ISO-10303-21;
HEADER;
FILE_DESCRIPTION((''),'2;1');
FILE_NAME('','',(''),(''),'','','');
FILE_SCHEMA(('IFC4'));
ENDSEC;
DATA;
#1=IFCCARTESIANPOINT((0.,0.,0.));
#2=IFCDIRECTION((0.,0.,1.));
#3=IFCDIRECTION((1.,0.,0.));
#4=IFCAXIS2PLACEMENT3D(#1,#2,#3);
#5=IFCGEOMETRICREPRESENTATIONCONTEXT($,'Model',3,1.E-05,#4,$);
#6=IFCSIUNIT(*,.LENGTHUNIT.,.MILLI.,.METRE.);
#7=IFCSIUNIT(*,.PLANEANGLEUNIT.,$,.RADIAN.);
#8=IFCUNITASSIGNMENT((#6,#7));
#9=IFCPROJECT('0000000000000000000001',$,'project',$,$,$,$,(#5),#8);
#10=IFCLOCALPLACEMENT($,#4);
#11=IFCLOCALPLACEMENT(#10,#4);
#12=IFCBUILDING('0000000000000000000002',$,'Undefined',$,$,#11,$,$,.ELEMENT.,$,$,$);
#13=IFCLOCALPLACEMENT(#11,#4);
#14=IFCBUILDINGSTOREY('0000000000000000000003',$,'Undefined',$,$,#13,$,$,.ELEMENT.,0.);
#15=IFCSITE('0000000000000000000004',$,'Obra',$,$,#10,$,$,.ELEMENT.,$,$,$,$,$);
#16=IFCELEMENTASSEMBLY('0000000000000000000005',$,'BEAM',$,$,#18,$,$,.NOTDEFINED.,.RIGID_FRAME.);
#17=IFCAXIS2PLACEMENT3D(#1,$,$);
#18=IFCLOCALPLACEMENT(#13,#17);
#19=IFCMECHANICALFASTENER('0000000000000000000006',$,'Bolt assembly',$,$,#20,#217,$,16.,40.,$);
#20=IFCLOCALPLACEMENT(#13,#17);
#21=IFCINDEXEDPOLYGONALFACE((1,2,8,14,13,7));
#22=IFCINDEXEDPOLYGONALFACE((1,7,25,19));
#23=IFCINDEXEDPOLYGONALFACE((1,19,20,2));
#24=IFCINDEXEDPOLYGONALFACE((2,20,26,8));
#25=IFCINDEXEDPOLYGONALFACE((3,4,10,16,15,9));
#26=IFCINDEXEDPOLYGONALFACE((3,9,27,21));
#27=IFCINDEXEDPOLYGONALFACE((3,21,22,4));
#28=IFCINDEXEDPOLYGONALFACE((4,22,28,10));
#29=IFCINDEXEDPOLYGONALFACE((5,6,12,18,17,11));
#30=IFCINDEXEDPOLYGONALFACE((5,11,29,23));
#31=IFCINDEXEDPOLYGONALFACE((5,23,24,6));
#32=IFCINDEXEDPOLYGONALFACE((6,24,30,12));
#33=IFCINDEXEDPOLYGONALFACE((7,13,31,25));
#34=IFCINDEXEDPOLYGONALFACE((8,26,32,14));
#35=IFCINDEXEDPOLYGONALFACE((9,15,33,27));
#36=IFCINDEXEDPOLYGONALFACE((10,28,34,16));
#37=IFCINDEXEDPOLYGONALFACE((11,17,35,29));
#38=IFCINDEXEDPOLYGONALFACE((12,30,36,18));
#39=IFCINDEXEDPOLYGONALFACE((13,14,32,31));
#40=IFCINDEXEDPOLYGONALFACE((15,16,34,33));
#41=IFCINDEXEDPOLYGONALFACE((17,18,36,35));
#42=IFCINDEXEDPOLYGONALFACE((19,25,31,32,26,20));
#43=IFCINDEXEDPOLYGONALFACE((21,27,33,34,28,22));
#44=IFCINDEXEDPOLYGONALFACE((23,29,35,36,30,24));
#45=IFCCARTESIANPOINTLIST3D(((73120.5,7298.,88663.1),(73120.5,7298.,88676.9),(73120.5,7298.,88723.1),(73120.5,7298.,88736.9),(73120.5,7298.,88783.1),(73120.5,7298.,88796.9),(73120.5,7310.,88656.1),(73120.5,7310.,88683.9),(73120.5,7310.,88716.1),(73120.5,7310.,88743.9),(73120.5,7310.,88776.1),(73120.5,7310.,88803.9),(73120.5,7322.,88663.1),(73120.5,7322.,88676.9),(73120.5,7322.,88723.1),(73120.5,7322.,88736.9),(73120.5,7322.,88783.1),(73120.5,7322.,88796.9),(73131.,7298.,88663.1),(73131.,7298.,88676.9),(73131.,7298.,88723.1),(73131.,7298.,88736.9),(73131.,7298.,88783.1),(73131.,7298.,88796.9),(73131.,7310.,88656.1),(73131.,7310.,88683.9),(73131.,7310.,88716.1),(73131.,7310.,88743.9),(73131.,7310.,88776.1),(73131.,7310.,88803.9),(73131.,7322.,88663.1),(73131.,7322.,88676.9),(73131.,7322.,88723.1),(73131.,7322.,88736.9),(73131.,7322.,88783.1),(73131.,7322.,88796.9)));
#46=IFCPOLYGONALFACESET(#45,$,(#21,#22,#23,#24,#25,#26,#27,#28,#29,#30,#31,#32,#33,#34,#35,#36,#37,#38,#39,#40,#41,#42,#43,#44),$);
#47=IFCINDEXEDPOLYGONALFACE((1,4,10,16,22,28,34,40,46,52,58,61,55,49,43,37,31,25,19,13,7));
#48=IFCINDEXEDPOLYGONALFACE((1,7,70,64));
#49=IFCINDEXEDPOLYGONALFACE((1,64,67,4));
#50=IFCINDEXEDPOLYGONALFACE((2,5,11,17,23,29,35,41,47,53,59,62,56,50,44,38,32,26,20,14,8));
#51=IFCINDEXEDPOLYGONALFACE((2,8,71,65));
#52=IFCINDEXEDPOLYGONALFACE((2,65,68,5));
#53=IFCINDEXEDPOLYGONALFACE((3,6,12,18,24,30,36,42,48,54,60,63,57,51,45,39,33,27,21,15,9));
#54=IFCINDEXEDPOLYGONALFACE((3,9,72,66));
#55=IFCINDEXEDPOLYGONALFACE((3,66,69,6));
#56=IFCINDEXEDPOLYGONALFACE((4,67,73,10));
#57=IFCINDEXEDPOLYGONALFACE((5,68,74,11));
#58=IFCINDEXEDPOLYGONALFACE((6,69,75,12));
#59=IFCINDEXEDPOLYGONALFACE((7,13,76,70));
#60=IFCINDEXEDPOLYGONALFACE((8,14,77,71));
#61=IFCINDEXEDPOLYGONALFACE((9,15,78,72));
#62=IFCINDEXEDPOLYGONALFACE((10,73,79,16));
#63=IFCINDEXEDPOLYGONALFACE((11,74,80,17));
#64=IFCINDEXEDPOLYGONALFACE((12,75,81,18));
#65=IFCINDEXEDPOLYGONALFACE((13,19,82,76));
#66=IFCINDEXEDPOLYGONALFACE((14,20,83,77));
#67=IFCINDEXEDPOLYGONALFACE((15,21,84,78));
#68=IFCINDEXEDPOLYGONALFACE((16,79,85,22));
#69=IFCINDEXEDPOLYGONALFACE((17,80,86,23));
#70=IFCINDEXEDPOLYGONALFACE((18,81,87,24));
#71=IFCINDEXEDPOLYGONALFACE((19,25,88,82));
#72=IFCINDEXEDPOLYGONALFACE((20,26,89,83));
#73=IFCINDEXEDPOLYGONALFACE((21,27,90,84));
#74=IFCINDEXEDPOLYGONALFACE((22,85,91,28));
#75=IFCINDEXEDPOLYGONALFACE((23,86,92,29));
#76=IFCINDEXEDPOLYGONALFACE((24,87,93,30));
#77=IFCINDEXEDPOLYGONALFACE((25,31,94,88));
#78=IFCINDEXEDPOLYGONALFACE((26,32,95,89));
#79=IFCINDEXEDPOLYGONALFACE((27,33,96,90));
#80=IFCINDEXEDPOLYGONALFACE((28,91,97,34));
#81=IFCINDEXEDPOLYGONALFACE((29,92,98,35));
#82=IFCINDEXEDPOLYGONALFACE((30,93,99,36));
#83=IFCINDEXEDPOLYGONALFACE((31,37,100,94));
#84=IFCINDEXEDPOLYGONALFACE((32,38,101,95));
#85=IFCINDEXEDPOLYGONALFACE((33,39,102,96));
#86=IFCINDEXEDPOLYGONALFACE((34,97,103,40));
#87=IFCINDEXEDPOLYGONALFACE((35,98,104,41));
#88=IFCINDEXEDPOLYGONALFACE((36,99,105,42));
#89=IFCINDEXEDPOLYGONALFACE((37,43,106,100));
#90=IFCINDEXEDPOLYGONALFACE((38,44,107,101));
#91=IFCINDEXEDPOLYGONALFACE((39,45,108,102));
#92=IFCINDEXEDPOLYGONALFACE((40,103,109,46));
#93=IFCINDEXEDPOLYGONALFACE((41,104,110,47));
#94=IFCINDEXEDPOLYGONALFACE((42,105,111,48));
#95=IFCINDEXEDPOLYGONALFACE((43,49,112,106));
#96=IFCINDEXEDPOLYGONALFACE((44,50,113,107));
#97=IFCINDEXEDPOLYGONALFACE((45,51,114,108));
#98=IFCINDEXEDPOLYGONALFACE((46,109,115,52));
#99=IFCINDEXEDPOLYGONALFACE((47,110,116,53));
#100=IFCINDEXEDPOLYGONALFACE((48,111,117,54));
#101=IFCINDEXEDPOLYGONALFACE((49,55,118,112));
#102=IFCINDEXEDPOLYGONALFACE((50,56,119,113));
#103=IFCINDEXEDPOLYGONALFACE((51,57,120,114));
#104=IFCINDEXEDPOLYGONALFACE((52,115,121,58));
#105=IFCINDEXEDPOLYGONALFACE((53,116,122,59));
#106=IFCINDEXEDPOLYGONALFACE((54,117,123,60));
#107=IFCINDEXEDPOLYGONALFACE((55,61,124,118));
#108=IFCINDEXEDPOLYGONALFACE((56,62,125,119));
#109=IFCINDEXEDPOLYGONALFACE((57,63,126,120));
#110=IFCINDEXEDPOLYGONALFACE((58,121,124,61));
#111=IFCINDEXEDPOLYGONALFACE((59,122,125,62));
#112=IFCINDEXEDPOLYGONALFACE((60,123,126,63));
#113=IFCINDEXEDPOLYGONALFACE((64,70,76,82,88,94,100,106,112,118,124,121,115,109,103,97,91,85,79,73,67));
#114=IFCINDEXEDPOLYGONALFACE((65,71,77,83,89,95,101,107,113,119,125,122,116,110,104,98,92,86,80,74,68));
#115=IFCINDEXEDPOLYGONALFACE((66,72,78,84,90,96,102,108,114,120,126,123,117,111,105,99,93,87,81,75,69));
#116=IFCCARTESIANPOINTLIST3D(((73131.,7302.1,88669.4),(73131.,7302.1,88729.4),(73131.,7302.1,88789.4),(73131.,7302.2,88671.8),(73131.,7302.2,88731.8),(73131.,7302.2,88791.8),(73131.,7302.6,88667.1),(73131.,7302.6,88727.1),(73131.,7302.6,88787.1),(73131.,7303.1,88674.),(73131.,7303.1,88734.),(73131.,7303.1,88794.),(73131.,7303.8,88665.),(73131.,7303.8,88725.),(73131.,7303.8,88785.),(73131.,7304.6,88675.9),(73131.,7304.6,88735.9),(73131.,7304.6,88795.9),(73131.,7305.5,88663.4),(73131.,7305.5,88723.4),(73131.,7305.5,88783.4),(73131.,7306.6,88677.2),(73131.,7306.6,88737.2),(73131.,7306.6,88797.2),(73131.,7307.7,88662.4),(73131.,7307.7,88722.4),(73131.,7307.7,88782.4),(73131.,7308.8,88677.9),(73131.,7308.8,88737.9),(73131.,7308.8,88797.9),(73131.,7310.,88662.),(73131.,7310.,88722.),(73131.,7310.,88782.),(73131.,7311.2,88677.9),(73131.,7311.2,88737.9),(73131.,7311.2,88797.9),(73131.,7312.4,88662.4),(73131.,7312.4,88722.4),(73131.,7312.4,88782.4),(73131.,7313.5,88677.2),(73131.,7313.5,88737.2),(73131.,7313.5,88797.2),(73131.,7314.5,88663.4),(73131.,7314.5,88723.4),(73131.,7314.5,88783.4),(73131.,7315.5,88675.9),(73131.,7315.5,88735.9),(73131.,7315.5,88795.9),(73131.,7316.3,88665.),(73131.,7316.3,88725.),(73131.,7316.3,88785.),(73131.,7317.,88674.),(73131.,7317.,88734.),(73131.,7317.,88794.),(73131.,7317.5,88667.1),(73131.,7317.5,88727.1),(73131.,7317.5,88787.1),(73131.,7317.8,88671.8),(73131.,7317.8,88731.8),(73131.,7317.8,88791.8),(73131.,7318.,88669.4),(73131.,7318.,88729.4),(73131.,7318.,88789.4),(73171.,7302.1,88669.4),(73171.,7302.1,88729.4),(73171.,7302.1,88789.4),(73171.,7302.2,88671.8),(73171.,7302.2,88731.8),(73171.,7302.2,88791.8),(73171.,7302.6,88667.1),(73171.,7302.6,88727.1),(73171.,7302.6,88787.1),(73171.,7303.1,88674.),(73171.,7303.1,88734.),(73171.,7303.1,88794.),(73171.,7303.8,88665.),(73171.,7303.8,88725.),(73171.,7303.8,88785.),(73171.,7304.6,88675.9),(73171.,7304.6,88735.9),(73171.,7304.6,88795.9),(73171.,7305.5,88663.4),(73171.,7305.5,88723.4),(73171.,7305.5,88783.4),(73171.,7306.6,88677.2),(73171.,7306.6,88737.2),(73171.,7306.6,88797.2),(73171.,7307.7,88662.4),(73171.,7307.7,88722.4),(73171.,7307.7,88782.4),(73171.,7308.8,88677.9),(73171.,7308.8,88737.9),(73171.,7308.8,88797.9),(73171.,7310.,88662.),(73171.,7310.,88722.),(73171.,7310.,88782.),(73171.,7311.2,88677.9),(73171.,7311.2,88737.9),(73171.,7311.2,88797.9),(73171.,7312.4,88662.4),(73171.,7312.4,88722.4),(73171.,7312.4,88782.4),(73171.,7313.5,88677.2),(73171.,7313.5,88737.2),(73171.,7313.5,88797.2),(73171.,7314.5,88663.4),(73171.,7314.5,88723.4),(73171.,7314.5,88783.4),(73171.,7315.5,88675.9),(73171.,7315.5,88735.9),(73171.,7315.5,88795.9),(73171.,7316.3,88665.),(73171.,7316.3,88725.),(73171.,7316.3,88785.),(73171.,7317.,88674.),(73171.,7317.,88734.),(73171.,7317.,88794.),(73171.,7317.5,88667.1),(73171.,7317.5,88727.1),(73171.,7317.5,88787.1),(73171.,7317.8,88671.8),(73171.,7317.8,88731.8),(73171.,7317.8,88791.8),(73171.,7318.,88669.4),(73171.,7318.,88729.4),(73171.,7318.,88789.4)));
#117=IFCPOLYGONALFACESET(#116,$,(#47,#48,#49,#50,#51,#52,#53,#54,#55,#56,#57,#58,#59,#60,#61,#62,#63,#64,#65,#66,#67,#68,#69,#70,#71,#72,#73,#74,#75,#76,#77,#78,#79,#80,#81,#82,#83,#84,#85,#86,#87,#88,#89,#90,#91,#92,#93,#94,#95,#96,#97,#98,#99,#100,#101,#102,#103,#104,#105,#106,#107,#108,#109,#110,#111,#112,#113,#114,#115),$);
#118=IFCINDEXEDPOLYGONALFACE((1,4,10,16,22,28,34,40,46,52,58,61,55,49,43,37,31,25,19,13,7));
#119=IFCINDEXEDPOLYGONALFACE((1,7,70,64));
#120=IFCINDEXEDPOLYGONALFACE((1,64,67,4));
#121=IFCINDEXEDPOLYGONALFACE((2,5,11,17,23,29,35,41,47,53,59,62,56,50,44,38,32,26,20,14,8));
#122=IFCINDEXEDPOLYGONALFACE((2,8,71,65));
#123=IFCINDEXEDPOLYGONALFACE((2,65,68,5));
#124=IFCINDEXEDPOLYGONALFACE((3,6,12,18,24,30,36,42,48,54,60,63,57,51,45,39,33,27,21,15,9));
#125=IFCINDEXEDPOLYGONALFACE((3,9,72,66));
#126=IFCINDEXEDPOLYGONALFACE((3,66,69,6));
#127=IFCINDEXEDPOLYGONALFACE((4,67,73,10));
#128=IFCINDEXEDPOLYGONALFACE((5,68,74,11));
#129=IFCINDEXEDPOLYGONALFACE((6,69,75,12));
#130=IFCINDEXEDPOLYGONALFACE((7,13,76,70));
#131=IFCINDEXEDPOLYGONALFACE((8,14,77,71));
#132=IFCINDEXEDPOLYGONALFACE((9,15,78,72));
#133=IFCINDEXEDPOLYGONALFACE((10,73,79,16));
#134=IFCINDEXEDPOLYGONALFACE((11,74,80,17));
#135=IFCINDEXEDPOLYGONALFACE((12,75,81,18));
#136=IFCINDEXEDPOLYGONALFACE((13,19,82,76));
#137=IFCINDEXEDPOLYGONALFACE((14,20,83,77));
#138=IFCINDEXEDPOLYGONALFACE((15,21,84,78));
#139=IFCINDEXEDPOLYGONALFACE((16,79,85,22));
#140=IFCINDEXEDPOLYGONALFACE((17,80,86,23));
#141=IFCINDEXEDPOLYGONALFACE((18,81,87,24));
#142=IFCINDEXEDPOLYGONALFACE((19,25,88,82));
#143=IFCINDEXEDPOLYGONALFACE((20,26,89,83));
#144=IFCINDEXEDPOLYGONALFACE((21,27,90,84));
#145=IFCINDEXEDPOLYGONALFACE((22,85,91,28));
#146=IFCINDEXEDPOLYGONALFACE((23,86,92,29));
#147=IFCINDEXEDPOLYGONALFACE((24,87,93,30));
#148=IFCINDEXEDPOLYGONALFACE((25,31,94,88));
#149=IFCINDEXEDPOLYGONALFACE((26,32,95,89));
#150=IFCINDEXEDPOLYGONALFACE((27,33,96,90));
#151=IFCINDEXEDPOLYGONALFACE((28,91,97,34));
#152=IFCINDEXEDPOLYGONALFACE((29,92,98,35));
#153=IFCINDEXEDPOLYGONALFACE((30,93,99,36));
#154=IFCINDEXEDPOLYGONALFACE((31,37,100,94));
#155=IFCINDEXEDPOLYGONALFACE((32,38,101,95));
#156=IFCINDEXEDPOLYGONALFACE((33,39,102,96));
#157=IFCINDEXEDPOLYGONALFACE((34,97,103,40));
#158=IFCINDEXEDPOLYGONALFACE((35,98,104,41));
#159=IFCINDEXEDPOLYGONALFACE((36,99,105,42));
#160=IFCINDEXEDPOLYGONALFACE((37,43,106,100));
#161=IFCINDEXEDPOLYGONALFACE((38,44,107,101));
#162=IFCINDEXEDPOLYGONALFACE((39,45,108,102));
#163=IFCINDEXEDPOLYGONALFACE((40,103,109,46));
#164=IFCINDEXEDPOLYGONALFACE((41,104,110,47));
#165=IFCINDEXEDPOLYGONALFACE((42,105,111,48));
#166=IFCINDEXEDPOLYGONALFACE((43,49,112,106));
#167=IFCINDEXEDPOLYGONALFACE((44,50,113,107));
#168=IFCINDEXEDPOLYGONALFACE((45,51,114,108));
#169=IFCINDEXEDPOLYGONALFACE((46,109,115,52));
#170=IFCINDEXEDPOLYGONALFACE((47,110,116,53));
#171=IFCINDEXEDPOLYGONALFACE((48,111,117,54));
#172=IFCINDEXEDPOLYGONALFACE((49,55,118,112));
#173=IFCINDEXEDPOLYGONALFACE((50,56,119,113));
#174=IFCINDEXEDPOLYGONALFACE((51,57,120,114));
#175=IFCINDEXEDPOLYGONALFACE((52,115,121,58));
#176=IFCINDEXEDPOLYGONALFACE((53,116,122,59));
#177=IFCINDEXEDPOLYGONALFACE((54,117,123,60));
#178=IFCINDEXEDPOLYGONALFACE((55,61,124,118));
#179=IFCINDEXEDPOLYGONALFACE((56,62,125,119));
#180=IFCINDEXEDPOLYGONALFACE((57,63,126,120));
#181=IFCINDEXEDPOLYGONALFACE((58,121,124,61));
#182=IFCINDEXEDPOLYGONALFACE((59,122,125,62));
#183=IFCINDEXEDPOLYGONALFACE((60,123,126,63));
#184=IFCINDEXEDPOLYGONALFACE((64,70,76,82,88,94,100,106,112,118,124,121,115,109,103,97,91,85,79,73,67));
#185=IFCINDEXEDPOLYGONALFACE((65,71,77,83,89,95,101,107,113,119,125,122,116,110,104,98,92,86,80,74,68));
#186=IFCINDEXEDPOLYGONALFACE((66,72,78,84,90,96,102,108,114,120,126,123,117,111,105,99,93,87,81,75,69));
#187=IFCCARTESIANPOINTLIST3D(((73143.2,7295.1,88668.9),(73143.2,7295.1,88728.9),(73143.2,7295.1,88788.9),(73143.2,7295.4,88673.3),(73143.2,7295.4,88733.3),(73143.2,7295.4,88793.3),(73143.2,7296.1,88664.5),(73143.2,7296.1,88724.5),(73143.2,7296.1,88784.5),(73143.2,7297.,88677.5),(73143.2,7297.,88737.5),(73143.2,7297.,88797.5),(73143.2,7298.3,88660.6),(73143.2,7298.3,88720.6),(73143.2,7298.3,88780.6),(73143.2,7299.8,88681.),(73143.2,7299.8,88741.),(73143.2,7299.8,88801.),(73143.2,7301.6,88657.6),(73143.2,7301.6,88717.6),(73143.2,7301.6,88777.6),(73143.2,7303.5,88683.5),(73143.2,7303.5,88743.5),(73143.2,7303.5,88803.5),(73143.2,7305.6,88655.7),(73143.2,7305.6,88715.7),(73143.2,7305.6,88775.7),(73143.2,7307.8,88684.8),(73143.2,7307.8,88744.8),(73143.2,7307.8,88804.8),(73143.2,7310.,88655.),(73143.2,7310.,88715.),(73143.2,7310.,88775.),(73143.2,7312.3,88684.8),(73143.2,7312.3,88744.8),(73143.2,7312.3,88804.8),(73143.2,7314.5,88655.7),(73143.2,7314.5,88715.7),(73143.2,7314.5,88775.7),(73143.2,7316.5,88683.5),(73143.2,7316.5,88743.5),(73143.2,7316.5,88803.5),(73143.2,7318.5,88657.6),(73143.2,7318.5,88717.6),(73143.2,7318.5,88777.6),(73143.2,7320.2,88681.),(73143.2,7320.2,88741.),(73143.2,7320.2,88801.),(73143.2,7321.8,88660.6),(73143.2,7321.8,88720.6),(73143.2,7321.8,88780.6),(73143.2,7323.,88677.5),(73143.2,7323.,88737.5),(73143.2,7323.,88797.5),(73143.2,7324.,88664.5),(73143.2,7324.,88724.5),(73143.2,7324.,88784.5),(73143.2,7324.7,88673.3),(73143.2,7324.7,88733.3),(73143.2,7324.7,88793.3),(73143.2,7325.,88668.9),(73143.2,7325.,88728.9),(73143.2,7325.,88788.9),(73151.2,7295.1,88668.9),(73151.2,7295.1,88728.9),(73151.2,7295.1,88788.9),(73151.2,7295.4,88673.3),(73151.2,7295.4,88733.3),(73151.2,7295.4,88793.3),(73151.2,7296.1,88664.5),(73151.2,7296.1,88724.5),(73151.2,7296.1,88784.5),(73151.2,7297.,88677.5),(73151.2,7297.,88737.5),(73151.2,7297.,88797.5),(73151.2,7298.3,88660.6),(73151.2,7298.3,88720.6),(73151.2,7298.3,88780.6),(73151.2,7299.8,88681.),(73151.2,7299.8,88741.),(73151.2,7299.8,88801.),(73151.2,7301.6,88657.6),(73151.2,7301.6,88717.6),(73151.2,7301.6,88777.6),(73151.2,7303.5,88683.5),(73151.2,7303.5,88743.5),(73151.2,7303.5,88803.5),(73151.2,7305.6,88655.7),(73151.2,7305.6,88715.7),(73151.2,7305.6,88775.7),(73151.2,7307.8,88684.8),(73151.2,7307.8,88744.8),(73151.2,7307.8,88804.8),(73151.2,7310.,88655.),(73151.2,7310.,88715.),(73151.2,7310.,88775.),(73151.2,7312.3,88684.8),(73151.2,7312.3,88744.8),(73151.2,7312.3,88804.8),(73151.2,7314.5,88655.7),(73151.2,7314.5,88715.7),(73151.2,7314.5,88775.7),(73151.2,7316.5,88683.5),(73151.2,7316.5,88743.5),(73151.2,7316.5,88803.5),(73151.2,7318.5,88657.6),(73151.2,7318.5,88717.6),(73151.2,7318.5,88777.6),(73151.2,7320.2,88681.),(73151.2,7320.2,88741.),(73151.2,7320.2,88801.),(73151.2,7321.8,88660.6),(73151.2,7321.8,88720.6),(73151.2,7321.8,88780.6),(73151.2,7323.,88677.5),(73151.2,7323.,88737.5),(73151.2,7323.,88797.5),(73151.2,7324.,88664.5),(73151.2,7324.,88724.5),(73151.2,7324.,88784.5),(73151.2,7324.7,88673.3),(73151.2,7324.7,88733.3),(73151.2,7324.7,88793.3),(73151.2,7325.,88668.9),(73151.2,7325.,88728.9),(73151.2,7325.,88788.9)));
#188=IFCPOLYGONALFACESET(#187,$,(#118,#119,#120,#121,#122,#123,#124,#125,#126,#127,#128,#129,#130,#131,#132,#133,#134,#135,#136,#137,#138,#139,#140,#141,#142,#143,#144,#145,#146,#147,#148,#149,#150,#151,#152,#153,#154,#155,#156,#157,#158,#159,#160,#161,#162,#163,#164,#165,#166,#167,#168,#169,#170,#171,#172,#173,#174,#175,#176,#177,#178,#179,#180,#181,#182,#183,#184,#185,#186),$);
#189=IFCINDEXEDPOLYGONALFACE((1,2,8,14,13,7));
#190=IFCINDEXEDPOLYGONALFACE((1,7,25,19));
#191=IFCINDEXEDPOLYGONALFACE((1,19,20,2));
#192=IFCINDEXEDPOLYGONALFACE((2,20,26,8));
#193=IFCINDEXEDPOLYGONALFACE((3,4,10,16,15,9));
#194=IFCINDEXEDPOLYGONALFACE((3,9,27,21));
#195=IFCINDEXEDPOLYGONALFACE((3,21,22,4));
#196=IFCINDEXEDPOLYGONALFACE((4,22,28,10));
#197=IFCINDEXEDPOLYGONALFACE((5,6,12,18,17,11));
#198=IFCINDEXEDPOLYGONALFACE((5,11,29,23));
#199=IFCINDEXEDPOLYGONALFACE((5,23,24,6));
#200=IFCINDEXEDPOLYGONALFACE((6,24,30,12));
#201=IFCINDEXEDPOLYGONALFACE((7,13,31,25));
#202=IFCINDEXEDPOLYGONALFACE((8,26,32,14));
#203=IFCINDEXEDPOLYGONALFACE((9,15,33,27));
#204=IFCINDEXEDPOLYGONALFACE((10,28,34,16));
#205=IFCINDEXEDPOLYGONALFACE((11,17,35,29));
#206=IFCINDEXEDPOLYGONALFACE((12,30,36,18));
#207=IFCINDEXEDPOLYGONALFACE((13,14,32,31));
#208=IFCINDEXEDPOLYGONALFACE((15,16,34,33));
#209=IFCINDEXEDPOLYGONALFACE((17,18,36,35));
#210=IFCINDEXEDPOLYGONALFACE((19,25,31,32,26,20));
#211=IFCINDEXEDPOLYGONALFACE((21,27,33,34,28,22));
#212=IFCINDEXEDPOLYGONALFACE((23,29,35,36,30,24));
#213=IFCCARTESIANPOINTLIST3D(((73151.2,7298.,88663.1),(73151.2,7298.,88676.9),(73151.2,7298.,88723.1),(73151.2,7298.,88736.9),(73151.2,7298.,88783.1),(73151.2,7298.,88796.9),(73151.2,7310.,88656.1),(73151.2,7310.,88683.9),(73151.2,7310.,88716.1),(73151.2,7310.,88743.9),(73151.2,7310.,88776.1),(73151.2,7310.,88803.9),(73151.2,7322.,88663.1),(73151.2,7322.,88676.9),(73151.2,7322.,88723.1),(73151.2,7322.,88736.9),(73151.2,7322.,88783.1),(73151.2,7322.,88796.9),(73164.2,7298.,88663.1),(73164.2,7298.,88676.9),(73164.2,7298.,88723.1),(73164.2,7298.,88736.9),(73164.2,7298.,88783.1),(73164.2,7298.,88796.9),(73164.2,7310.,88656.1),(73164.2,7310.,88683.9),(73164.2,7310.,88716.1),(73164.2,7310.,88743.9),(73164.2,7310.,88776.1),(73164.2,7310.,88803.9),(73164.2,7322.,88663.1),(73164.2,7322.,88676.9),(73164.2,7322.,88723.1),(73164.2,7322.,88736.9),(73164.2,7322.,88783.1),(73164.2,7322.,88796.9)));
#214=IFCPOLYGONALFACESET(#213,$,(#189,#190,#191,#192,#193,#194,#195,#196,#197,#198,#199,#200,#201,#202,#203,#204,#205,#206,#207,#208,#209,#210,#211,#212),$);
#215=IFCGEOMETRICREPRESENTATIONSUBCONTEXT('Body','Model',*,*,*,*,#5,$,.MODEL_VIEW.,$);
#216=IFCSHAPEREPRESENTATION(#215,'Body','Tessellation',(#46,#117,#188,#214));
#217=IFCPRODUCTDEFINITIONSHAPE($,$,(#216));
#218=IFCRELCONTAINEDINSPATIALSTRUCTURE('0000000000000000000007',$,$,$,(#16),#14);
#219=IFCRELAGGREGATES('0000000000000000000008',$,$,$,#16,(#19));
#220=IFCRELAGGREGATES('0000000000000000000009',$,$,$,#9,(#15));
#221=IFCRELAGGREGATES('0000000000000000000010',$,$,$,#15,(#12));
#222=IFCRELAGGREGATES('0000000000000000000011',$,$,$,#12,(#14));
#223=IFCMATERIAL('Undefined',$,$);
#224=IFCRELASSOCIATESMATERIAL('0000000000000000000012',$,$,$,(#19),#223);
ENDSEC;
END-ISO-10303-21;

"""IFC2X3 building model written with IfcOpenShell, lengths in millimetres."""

from ifc_helpers import new_model, si_unit, frame, origin_with_axes, origin_2d_with_axis, place, context, subcontext, project, spatial, polyline, circle, outline, extrude, source, transform, mapped, material, element, aggregate, save


model = new_model("IFC2X3")

# Units and contexts
model_context = context("Model", 3, precision=1e-05, world=origin_with_axes())
body_context = subcontext(model_context, "Body", "Model", "MODEL_VIEW")
ifc_project = project(units=[si_unit("LENGTHUNIT", "METRE", prefix="MILLI"), si_unit("PLANEANGLEUNIT", "RADIAN")], contexts=[model_context])

# Site, building, storey
site_placement = place(None, origin_with_axes())
site = spatial("IfcSite", under=ifc_project, at=site_placement, Name="Obra", CompositionType="ELEMENT")
building_placement = place(site_placement, origin_with_axes())
building = spatial("IfcBuilding", under=site, at=building_placement, Name="Undefined", CompositionType="ELEMENT")
storey_placement = place(building_placement, origin_with_axes())
storey = spatial("IfcBuildingStorey", under=building, at=storey_placement, Name="Undefined", CompositionType="ELEMENT", Elevation=0.0)

# Shared definitions
ifc_material_1 = material(Name="Undefined")

# Element assembly, mechanical fastener
assembly_1_placement = place(storey_placement, origin_with_axes())
assembly_1 = element("IfcElementAssembly", 1, at=assembly_1_placement, inside=storey, Name="BEAM", AssemblyPlace="NOTDEFINED", PredefinedType="RIGID_FRAME")
shared_shape_1 = source(origin_with_axes(), body_context, "Body", "SweptSolid", [
    extrude(outline(polyline([(13.9, 0.0), (6.9, 12.0), (-6.9, 12.0), (-13.9, 0.0), (-6.9, -12.0), (6.9, -12.0), (13.9, 0.0)])), frame((0.0, -19.7, 0.0), z_axis=(0.0, 1.0, 0.0), x_axis=(1.0, 0.0, 0.0)), (0.0, 0.0, 1.0), 10.6),
    extrude(circle(Radius=8.0, at=origin_2d_with_axis()), frame((0.0, -9.1, 0.0), z_axis=(0.0, 1.0, 0.0), x_axis=(1.0, 0.0, 0.0)), (0.0, 0.0, 1.0), 40.0),
    extrude(circle(Radius=15.0, at=origin_2d_with_axis()), frame((0.0, 3.1, 0.0), z_axis=(0.0, 1.0, 0.0), x_axis=(1.0, 0.0, 0.0)), (0.0, 0.0, 1.0), 8.0),
    extrude(outline(polyline([(13.9, 0.0), (6.9, 12.0), (-6.9, 12.0), (-13.9, 0.0), (-6.9, -12.0), (6.9, -12.0), (13.9, 0.0)])), frame((0.0, 11.1, 0.0), z_axis=(0.0, 1.0, 0.0), x_axis=(1.0, 0.0, 0.0)), (0.0, 0.0, 1.0), 13.0),
])
mechanical_fastener_1_placement = place(assembly_1_placement, frame((73140.1, 7360.0, 88850.0), z_axis=(-0.000019, -1.0, 0.0), x_axis=(0.0, 0.0, -1.0)))
mechanical_fastener_1 = element("IfcMechanicalFastener", 2, at=mechanical_fastener_1_placement, material=ifc_material_1, Name="Bolt assembly", NominalDiameter=16.0, NominalLength=40.0, context=body_context, shape_type="MappedRepresentation", body=[
    mapped(shared_shape_1, transform((60.0, 0.0, 50.0))),
    mapped(shared_shape_1, transform((120.0, 0.0, 50.0))),
    mapped(shared_shape_1, transform((180.0, 0.0, 50.0))),
])
aggregate(assembly_1, [mechanical_fastener_1])

save(model, "model.ifc")
